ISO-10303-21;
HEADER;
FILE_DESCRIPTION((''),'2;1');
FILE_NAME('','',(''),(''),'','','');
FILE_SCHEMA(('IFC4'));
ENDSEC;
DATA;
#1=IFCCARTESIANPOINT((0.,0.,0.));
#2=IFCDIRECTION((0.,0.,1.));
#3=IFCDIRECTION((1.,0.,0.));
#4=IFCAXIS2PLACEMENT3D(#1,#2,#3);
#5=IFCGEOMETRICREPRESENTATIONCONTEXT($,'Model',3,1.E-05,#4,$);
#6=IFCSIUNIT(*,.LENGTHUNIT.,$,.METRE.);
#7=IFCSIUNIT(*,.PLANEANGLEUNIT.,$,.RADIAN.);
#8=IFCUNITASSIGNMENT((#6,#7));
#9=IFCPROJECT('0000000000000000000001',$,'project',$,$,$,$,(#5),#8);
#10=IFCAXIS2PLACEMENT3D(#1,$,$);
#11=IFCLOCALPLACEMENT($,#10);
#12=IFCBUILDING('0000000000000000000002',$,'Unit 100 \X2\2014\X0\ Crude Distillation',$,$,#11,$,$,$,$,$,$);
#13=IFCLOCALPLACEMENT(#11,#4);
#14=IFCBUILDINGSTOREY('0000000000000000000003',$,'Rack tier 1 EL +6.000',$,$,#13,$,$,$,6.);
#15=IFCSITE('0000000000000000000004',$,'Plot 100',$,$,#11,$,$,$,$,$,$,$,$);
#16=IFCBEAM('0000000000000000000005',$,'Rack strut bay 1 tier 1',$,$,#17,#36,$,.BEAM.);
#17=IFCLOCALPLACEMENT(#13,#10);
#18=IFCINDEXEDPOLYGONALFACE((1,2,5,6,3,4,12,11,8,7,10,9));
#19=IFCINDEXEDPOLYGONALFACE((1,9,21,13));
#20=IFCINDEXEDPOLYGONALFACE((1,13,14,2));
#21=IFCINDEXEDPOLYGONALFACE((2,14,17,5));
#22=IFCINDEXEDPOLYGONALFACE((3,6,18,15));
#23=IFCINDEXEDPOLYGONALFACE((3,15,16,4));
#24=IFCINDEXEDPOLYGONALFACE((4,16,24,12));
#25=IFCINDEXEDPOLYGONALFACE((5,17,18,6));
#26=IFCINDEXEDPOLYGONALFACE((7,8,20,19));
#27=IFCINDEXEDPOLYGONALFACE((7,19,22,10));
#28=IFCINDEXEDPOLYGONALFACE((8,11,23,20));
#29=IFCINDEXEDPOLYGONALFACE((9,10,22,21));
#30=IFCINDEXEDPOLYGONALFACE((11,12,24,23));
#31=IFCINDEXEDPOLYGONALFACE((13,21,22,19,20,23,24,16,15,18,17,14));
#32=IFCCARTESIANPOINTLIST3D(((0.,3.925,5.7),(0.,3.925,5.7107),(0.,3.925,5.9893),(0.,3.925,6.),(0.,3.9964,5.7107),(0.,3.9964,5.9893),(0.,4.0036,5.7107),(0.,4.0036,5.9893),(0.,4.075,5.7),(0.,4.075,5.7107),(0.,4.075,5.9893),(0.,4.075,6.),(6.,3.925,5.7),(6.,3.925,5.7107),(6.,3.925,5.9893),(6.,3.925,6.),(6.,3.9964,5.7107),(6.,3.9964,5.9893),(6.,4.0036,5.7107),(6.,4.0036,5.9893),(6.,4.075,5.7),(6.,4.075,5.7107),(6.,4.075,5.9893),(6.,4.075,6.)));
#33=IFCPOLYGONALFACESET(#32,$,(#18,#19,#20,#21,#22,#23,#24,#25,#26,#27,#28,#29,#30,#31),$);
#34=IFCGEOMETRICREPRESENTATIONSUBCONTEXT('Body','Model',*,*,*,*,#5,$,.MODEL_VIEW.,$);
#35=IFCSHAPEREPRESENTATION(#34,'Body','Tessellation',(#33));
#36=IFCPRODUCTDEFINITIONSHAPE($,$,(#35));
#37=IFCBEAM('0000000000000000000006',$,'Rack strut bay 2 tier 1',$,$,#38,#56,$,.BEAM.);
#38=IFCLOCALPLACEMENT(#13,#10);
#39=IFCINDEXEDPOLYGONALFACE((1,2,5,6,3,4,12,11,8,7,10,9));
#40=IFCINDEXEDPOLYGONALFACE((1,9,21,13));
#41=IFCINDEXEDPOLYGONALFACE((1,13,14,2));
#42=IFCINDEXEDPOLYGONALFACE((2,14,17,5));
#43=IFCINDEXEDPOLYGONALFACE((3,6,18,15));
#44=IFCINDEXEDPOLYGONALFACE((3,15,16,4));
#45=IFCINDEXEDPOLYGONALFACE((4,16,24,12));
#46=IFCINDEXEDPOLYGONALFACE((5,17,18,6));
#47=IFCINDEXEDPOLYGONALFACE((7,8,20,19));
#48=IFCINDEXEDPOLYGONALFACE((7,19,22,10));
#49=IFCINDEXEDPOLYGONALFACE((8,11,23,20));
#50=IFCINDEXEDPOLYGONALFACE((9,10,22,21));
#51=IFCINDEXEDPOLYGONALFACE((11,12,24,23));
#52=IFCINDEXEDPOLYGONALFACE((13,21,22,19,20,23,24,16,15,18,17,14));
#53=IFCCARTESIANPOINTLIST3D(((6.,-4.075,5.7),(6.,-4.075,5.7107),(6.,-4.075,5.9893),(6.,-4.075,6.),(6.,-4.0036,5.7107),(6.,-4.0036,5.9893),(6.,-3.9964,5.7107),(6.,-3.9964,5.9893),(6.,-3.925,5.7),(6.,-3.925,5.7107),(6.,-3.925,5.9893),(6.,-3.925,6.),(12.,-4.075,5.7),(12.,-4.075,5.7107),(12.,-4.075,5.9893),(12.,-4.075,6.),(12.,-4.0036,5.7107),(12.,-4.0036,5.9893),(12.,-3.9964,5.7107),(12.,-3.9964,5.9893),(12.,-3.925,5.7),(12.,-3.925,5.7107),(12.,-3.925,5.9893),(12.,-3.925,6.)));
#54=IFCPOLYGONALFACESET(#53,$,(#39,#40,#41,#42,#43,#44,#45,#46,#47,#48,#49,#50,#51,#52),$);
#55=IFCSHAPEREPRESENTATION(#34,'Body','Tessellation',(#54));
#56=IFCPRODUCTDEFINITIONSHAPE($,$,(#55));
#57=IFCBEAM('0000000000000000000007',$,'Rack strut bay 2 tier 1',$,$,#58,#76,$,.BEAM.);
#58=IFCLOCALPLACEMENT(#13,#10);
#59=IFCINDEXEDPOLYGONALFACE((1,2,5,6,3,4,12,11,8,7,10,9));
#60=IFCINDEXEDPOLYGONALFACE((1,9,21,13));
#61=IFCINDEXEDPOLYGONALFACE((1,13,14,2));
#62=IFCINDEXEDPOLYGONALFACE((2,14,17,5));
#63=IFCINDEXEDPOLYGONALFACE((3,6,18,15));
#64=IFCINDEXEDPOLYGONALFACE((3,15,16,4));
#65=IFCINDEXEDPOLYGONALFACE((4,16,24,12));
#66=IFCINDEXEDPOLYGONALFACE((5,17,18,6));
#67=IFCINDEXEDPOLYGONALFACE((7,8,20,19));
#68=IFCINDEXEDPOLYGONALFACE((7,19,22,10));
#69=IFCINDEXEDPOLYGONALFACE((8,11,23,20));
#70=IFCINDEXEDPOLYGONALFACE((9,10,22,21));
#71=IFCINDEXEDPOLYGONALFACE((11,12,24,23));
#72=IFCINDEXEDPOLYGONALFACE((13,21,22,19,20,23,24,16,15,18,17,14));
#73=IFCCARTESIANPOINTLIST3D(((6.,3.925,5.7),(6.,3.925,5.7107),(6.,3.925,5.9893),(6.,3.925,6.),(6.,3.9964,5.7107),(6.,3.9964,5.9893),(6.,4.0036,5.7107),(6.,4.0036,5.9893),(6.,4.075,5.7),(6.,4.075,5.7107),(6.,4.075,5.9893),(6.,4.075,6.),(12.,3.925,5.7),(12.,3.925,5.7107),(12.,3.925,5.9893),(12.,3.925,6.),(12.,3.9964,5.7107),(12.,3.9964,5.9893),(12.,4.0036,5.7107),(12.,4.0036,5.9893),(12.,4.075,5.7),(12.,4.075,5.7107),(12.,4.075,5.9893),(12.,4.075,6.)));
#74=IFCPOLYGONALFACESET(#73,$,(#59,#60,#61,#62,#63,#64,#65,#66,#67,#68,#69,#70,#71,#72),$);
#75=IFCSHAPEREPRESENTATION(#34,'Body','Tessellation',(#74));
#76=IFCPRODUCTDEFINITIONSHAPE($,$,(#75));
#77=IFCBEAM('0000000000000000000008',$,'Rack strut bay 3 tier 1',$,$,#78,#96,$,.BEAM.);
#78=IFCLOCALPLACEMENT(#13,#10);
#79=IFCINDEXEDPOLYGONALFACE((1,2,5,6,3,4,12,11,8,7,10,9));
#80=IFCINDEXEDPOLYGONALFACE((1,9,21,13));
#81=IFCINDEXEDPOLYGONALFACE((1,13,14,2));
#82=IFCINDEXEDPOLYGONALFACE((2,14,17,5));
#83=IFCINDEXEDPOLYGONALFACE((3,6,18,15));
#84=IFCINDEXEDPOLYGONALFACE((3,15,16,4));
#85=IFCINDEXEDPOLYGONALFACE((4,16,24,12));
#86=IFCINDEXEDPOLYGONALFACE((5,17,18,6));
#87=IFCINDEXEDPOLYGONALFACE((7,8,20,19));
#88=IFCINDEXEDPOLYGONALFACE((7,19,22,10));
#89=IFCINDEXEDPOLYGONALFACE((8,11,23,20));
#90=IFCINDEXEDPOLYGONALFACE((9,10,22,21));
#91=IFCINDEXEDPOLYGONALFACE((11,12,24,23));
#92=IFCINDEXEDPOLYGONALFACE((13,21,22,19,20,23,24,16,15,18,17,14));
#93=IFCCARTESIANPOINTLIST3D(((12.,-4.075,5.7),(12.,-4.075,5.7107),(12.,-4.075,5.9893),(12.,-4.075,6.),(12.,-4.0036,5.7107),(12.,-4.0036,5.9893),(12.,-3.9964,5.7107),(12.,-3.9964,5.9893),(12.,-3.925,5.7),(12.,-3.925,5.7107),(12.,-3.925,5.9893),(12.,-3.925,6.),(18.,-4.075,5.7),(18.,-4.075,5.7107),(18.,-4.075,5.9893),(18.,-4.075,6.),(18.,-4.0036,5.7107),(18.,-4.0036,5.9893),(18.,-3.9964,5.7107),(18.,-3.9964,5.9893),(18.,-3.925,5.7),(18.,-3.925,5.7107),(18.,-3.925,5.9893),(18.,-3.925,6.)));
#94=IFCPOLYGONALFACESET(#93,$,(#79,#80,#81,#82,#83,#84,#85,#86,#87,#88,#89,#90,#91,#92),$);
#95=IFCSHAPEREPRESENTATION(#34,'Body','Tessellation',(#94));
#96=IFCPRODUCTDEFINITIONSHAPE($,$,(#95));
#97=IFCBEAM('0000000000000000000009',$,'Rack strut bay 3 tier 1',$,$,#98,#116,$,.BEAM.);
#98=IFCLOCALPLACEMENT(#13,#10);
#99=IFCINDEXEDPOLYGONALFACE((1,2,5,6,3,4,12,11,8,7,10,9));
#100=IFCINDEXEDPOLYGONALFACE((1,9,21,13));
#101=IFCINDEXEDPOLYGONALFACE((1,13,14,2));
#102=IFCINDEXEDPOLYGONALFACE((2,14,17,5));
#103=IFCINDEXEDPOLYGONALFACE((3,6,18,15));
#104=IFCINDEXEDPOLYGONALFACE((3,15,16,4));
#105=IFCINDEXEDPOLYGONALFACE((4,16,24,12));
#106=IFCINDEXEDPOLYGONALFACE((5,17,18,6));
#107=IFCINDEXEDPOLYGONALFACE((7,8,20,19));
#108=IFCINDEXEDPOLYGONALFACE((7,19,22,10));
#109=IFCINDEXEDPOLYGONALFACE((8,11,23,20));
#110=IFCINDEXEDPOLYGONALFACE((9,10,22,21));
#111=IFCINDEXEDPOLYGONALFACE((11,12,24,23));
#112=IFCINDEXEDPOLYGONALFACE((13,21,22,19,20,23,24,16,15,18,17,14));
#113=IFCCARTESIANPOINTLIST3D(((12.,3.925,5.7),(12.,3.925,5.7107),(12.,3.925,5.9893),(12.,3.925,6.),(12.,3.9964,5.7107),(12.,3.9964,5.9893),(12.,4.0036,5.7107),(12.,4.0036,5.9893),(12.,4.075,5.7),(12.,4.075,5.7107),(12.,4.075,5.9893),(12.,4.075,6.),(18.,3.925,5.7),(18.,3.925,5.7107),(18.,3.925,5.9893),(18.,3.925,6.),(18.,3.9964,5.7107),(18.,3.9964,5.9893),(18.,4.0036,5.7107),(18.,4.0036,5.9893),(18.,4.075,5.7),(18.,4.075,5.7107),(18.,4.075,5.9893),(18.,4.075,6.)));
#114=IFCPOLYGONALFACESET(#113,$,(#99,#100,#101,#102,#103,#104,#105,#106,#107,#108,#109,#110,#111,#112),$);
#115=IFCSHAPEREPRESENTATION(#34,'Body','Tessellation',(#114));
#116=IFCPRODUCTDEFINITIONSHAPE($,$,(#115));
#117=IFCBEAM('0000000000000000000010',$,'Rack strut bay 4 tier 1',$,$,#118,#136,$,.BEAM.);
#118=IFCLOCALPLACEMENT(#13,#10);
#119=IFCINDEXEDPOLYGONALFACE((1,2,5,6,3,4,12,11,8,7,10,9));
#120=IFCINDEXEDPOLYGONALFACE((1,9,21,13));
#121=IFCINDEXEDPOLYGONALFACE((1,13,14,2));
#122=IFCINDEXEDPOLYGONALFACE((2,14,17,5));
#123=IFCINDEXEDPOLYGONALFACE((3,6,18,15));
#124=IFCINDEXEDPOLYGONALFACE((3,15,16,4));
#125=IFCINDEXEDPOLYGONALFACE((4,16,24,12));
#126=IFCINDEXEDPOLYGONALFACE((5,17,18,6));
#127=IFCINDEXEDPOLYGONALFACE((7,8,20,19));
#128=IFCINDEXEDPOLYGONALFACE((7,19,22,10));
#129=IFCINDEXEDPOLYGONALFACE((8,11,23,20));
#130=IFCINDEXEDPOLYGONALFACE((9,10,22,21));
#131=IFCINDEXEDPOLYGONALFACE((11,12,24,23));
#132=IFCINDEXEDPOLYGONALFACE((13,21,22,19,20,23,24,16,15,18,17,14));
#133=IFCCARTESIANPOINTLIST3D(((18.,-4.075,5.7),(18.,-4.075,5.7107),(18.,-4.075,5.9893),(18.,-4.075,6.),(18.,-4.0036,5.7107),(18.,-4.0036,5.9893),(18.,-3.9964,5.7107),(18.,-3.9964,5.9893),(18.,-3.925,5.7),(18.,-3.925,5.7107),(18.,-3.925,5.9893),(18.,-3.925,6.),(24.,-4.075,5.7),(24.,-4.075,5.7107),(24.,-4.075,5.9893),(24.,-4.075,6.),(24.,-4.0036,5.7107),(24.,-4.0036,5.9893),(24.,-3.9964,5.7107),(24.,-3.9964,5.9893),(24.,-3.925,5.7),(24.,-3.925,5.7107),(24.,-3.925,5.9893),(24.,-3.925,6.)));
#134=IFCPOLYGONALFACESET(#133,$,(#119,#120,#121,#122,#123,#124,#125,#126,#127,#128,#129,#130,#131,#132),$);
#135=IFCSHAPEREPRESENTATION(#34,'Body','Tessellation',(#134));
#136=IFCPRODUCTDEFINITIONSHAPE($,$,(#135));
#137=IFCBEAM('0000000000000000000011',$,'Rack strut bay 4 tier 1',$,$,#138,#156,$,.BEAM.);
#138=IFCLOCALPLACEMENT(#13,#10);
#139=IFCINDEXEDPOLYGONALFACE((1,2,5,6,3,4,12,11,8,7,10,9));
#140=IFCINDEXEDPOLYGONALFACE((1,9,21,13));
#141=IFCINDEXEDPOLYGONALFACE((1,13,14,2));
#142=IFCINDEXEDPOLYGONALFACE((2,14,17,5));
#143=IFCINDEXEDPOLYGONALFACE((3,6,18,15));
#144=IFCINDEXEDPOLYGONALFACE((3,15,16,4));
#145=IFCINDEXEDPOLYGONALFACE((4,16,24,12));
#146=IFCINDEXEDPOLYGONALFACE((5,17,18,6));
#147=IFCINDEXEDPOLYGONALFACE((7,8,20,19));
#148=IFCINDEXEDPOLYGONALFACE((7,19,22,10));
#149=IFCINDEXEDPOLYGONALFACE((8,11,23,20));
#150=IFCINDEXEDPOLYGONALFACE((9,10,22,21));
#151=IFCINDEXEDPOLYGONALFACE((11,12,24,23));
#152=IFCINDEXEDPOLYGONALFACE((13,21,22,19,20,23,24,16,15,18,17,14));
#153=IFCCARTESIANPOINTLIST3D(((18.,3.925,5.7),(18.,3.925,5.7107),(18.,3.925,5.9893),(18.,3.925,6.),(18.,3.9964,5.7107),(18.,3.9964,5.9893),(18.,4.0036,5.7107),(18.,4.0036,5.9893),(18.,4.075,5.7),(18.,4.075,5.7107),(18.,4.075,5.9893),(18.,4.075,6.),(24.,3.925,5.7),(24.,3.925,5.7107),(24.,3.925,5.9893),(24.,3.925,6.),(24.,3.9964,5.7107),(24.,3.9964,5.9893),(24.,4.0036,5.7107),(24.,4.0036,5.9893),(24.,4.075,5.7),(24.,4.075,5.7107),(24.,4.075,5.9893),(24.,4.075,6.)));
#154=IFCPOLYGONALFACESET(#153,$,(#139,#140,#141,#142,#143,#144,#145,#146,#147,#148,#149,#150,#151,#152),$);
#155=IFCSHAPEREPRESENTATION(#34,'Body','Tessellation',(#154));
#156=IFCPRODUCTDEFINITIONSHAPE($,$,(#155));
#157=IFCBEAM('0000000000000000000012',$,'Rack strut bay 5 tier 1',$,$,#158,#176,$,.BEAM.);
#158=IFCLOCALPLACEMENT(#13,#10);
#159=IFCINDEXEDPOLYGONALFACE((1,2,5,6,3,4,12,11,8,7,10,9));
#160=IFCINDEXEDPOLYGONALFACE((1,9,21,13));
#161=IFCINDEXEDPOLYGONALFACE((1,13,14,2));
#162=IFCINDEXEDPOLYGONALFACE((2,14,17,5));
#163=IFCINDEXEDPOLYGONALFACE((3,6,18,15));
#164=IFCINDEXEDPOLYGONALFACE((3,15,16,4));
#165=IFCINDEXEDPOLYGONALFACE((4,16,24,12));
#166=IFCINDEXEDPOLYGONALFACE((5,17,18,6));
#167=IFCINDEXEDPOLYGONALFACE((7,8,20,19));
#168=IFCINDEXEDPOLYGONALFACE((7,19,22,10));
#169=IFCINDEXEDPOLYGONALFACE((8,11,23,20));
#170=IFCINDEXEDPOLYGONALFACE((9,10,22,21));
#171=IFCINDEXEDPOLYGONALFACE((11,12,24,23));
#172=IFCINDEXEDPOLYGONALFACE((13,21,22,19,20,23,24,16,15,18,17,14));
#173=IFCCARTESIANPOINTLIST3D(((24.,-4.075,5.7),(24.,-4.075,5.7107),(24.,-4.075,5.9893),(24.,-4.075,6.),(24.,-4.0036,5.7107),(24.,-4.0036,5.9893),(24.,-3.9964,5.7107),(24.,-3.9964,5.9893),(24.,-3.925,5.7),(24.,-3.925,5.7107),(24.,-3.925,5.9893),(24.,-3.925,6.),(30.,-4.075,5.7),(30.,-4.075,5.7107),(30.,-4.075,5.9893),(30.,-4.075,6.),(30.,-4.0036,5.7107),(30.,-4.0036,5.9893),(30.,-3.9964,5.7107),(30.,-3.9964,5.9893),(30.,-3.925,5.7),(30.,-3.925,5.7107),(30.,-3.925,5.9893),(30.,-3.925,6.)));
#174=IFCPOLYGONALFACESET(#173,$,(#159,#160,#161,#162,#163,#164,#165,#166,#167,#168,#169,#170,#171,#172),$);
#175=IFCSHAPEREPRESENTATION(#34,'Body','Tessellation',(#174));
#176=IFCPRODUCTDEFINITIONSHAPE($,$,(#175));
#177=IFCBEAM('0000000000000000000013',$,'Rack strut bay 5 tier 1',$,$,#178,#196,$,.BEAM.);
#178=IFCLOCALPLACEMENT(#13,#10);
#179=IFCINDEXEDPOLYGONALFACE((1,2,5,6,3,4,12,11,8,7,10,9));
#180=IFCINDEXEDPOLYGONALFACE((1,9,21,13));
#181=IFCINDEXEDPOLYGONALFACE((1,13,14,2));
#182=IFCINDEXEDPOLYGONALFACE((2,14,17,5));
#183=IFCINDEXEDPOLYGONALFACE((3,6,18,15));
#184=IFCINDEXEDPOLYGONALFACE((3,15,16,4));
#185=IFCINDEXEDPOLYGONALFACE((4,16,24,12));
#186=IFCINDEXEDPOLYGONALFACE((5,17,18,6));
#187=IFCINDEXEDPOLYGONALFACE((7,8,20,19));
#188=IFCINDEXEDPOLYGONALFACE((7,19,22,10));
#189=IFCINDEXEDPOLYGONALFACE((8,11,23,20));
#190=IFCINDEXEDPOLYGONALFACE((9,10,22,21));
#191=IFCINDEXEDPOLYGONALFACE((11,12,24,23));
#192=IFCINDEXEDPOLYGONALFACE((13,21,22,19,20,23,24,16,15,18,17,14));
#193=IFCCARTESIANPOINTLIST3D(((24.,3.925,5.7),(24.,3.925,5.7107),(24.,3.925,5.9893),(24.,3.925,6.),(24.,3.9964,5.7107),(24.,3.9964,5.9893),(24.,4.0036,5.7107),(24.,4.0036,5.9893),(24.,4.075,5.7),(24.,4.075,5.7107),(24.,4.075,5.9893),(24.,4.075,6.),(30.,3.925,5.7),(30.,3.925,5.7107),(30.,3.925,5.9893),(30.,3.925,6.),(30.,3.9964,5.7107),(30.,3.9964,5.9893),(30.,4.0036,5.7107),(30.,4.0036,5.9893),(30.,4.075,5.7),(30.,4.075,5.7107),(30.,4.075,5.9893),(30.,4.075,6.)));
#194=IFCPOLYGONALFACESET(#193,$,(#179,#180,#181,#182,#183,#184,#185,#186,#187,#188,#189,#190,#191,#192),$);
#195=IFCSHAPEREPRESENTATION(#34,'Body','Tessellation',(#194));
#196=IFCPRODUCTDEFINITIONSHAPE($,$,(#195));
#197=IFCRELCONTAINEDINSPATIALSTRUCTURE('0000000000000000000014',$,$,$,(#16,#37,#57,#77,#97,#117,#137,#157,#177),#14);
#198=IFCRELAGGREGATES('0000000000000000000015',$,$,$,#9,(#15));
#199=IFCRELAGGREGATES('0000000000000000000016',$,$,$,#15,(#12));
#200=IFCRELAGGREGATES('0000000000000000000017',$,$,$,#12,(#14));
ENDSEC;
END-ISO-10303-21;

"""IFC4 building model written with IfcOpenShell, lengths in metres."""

from ifc_helpers import new_model, si_unit, frame, origin, origin_with_axes, origin_2d, place, context, subcontext, project, spatial, i_section, extrude, element, save


model = new_model("IFC4")

# Units and contexts
model_context = context("Model", 3, precision=1e-05, world=origin_with_axes())
body_context = subcontext(model_context, "Body", "Model", "MODEL_VIEW")
ifc_project = project(units=[si_unit("LENGTHUNIT", "METRE"), si_unit("PLANEANGLEUNIT", "RADIAN")], contexts=[model_context])

# Site, building, storey
placement = place(None, origin())
site = spatial("IfcSite", under=ifc_project, at=placement, Name="Plot 100")
building = spatial("IfcBuilding", under=site, at=placement, Name="Unit 100 — Crude Distillation")
storey_placement = place(placement, origin_with_axes())
storey = spatial("IfcBuildingStorey", under=building, at=storey_placement, Name="Rack tier 1 EL +6.000", Elevation=6.0)

# Beams
beam_1_placement = place(storey_placement, origin_with_axes())
element("IfcBeam", 1, at=beam_1_placement, inside=storey, Name="Rack strut bay 1 tier 1", PredefinedType="BEAM", context=body_context, shape_type="SweptSolid", body=[
    extrude(i_section(OverallWidth=0.15, OverallDepth=0.3, WebThickness=0.0071, FlangeThickness=0.0107, at=origin_2d()), frame((0.0, 4.0, 5.85), z_axis=(1.0, 0.0, 0.0), x_axis=(0.0, 1.0, 0.0)), (0.0, 0.0, 1.0), 6.0),
])
beam_2_placement = place(storey_placement, origin_with_axes())
element("IfcBeam", 2, at=beam_2_placement, inside=storey, Name="Rack strut bay 2 tier 1", PredefinedType="BEAM", context=body_context, shape_type="SweptSolid", body=[
    extrude(i_section(OverallWidth=0.15, OverallDepth=0.3, WebThickness=0.0071, FlangeThickness=0.0107, at=origin_2d()), frame((6.0, -4.0, 5.85), z_axis=(1.0, 0.0, 0.0), x_axis=(0.0, 1.0, 0.0)), (0.0, 0.0, 1.0), 6.0),
])
beam_3_placement = place(storey_placement, origin_with_axes())
element("IfcBeam", 3, at=beam_3_placement, inside=storey, Name="Rack strut bay 2 tier 1", PredefinedType="BEAM", context=body_context, shape_type="SweptSolid", body=[
    extrude(i_section(OverallWidth=0.15, OverallDepth=0.3, WebThickness=0.0071, FlangeThickness=0.0107, at=origin_2d()), frame((6.0, 4.0, 5.85), z_axis=(1.0, 0.0, 0.0), x_axis=(0.0, 1.0, 0.0)), (0.0, 0.0, 1.0), 6.0),
])
beam_4_placement = place(storey_placement, origin_with_axes())
element("IfcBeam", 4, at=beam_4_placement, inside=storey, Name="Rack strut bay 3 tier 1", PredefinedType="BEAM", context=body_context, shape_type="SweptSolid", body=[
    extrude(i_section(OverallWidth=0.15, OverallDepth=0.3, WebThickness=0.0071, FlangeThickness=0.0107, at=origin_2d()), frame((12.0, -4.0, 5.85), z_axis=(1.0, 0.0, 0.0), x_axis=(0.0, 1.0, 0.0)), (0.0, 0.0, 1.0), 6.0),
])
beam_5_placement = place(storey_placement, origin_with_axes())
element("IfcBeam", 5, at=beam_5_placement, inside=storey, Name="Rack strut bay 3 tier 1", PredefinedType="BEAM", context=body_context, shape_type="SweptSolid", body=[
    extrude(i_section(OverallWidth=0.15, OverallDepth=0.3, WebThickness=0.0071, FlangeThickness=0.0107, at=origin_2d()), frame((12.0, 4.0, 5.85), z_axis=(1.0, 0.0, 0.0), x_axis=(0.0, 1.0, 0.0)), (0.0, 0.0, 1.0), 6.0),
])
beam_6_placement = place(storey_placement, origin_with_axes())
element("IfcBeam", 6, at=beam_6_placement, inside=storey, Name="Rack strut bay 4 tier 1", PredefinedType="BEAM", context=body_context, shape_type="SweptSolid", body=[
    extrude(i_section(OverallWidth=0.15, OverallDepth=0.3, WebThickness=0.0071, FlangeThickness=0.0107, at=origin_2d()), frame((18.0, -4.0, 5.85), z_axis=(1.0, 0.0, 0.0), x_axis=(0.0, 1.0, 0.0)), (0.0, 0.0, 1.0), 6.0),
])
beam_7_placement = place(storey_placement, origin_with_axes())
element("IfcBeam", 7, at=beam_7_placement, inside=storey, Name="Rack strut bay 4 tier 1", PredefinedType="BEAM", context=body_context, shape_type="SweptSolid", body=[
    extrude(i_section(OverallWidth=0.15, OverallDepth=0.3, WebThickness=0.0071, FlangeThickness=0.0107, at=origin_2d()), frame((18.0, 4.0, 5.85), z_axis=(1.0, 0.0, 0.0), x_axis=(0.0, 1.0, 0.0)), (0.0, 0.0, 1.0), 6.0),
])
beam_8_placement = place(storey_placement, origin_with_axes())
element("IfcBeam", 8, at=beam_8_placement, inside=storey, Name="Rack strut bay 5 tier 1", PredefinedType="BEAM", context=body_context, shape_type="SweptSolid", body=[
    extrude(i_section(OverallWidth=0.15, OverallDepth=0.3, WebThickness=0.0071, FlangeThickness=0.0107, at=origin_2d()), frame((24.0, -4.0, 5.85), z_axis=(1.0, 0.0, 0.0), x_axis=(0.0, 1.0, 0.0)), (0.0, 0.0, 1.0), 6.0),
])
beam_9_placement = place(storey_placement, origin_with_axes())
element("IfcBeam", 9, at=beam_9_placement, inside=storey, Name="Rack strut bay 5 tier 1", PredefinedType="BEAM", context=body_context, shape_type="SweptSolid", body=[
    extrude(i_section(OverallWidth=0.15, OverallDepth=0.3, WebThickness=0.0071, FlangeThickness=0.0107, at=origin_2d()), frame((24.0, 4.0, 5.85), z_axis=(1.0, 0.0, 0.0), x_axis=(0.0, 1.0, 0.0)), (0.0, 0.0, 1.0), 6.0),
])

save(model, "model.ifc")
